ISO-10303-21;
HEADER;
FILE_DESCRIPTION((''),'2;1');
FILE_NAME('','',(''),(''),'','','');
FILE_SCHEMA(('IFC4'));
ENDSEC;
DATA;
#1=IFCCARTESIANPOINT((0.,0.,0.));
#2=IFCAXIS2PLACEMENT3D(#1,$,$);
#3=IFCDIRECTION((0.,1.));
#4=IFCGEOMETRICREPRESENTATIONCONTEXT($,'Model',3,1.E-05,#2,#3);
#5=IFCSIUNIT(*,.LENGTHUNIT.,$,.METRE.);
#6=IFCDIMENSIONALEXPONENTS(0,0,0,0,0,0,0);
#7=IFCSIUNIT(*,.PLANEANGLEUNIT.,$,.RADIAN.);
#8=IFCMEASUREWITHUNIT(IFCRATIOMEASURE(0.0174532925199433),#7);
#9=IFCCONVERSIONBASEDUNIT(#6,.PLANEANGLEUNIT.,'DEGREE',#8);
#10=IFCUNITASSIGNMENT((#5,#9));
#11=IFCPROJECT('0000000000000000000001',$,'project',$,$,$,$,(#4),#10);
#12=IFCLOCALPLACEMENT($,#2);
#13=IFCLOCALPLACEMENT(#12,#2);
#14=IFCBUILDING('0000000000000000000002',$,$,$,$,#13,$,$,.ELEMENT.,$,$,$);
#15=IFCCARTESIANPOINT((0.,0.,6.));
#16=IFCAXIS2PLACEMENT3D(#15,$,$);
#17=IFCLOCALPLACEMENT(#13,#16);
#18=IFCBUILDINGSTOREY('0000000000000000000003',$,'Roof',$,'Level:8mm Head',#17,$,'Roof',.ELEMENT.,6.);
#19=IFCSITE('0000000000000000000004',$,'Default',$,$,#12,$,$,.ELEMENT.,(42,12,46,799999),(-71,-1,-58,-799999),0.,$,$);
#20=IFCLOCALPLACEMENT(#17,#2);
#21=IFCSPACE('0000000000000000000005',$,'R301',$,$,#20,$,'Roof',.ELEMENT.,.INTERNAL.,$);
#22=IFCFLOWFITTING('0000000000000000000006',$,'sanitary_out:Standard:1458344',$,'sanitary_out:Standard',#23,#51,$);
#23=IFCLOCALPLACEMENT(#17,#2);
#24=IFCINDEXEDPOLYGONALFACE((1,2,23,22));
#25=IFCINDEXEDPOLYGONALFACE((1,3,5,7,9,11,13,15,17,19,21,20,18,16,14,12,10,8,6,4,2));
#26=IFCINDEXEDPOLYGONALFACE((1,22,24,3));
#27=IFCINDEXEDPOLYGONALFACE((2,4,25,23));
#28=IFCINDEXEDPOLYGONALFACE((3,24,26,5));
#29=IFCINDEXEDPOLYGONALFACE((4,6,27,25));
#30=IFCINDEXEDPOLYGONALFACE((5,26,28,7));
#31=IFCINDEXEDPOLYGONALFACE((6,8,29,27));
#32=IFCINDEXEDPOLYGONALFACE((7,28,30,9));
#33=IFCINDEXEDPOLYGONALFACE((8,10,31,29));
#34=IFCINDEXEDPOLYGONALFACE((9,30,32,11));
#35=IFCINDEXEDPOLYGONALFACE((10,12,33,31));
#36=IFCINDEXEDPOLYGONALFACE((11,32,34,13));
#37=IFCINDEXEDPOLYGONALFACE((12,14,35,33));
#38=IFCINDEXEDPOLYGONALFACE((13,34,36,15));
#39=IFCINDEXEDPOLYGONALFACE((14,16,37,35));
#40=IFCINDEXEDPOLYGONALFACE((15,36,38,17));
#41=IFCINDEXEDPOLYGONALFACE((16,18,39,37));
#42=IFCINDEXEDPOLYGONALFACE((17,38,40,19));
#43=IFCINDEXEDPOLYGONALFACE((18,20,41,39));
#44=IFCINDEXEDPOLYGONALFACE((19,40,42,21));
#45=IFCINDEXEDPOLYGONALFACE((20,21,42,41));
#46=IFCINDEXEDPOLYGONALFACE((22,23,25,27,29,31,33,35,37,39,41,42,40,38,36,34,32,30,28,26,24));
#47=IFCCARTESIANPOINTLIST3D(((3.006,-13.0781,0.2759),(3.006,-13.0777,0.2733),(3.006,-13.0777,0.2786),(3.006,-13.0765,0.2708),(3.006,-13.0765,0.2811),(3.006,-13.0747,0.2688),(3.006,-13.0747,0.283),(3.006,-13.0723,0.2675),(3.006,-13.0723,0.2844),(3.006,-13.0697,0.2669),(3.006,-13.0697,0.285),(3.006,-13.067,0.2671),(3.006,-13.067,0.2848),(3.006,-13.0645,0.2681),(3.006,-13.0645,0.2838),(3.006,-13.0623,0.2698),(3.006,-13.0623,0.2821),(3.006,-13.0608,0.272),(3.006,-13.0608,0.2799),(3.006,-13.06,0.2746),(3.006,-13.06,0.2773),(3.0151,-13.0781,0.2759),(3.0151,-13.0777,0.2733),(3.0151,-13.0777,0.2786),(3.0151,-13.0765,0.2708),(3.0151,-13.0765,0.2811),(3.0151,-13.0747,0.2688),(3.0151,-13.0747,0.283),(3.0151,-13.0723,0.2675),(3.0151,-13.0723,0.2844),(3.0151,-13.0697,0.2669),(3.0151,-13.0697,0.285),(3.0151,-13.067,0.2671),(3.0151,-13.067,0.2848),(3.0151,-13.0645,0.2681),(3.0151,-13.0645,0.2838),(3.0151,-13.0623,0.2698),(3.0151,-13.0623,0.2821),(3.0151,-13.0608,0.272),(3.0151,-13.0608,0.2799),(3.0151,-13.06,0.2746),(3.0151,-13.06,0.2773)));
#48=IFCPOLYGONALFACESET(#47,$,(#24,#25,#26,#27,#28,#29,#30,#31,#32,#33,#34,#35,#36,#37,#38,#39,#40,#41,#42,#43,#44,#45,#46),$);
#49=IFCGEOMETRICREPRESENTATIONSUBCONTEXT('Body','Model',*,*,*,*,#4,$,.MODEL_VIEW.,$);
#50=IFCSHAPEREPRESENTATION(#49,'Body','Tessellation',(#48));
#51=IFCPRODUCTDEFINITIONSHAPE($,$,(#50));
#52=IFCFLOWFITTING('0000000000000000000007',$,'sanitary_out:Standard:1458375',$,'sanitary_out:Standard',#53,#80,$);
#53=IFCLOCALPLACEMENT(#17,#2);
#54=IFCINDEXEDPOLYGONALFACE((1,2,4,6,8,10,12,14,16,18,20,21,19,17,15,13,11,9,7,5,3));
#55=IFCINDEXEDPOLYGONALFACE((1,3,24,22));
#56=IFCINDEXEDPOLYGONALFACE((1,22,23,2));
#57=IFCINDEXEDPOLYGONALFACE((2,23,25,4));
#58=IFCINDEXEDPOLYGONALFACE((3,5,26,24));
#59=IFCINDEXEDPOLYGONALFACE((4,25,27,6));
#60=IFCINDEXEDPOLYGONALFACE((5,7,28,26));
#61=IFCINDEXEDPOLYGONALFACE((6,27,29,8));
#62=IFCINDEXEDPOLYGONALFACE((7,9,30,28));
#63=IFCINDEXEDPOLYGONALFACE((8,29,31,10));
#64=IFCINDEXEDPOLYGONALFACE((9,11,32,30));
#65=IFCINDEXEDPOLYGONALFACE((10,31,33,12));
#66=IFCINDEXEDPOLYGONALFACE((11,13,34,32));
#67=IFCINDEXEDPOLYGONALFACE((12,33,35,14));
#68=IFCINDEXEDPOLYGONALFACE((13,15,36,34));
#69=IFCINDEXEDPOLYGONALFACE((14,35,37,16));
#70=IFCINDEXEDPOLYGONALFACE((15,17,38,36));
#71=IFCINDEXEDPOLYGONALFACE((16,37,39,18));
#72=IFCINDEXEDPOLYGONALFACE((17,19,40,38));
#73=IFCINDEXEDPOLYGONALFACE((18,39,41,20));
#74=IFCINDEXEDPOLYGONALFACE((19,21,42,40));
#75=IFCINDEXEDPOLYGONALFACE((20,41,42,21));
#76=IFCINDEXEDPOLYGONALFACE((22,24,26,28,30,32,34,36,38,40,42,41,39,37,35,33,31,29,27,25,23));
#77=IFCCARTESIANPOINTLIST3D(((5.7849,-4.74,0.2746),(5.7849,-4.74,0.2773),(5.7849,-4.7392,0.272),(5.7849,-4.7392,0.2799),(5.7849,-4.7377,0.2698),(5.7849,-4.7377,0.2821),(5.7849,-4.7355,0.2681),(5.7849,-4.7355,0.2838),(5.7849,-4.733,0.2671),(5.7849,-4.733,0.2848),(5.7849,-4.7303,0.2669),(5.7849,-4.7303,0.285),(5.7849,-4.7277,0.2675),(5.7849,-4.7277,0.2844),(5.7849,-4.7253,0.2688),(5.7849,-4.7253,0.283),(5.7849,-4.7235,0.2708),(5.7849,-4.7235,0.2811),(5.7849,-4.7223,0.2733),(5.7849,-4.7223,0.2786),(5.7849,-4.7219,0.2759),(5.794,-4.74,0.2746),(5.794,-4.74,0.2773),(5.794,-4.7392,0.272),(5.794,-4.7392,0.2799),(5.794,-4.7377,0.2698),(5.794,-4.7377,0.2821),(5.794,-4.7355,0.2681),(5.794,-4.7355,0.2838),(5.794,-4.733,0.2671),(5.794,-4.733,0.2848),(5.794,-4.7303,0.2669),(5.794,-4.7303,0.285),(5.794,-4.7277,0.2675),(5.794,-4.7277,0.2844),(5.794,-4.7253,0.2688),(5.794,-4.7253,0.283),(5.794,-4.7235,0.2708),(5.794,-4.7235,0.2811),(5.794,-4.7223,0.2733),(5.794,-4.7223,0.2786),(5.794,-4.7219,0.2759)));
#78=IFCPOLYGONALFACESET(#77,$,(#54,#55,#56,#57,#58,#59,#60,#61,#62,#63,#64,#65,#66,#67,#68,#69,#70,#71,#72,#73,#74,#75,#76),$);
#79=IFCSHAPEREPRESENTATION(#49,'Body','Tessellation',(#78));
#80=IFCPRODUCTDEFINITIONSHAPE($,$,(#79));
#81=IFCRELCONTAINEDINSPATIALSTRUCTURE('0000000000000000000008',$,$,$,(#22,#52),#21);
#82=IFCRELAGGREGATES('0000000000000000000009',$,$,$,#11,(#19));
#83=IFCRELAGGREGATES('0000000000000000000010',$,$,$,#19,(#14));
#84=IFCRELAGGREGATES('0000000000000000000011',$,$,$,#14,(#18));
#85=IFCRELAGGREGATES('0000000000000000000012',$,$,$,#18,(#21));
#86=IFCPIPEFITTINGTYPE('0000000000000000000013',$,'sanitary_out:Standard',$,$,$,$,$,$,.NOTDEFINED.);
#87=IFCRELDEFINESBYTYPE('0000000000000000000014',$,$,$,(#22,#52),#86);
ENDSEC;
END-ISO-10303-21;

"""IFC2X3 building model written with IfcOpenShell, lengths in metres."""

from ifc_helpers import new_model, entity, si_unit, converted_unit, direction, frame, frame_2d, origin, place, context, subcontext, project, spatial, circle, extrude, source, transform, mapped, type_object, type_shapes, element, save


model = new_model("IFC2X3")

# Units and contexts
model_context = context("Model", 3, precision=1e-05, world=origin(), true_north=direction((0.0, 1.0)))
body_context = subcontext(model_context, "Body", "Model", "MODEL_VIEW")
ifc_project = project(units=[si_unit("LENGTHUNIT", "METRE"), converted_unit("PLANEANGLEUNIT", "DEGREE", entity("IfcRatioMeasure", 0.0174532925199433), si_unit("PLANEANGLEUNIT", "RADIAN"), dimensions=[0, 0, 0, 0, 0, 0, 0])], contexts=[model_context])

# Site, building, storey
site_placement = place(None, origin())
site = spatial("IfcSite", under=ifc_project, at=site_placement, Name="Default", CompositionType="ELEMENT", RefLatitude=(42, 12, 46, 799999), RefLongitude=(-71, -1, -58, -799999), RefElevation=0.0)
building_placement = place(site_placement, origin())
building = spatial("IfcBuilding", under=site, at=building_placement, CompositionType="ELEMENT")
storey_placement = place(building_placement, frame((0.0, 0.0, 6.0)))
storey = spatial("IfcBuildingStorey", under=building, at=storey_placement, Name="Roof", ObjectType="Level:8mm Head", LongName="Roof", CompositionType="ELEMENT", Elevation=6.0)

# Shared definitions
space_placement = place(storey_placement, origin())
space = spatial("IfcSpace", under=storey, at=space_placement, Name="R301", LongName="Roof", CompositionType="ELEMENT", InteriorOrExteriorSpace="INTERNAL")

# Flow fittings
pipe_fitting_type = type_object("IfcPipeFittingType", Name="sanitary_out:Standard", PredefinedType="NOTDEFINED")
shared_shape = source(origin(), body_context, "Body", "SweptSolid", [
    extrude(circle(Radius=0.0091, at=frame_2d((0.0, 0.0), x_axis=(1.0, 0.0))), frame((0.0, 0.0, 0.0), z_axis=(1.0, 0.0, 0.0), x_axis=(0.0, 1.0, 0.0)), (0.0, 0.0, 1.0), 0.0091),
])
type_shapes(pipe_fitting_type, [shared_shape])
flow_fitting_1_placement = place(space_placement, frame((3.0151, -13.069, 0.2759), z_axis=(0.0, 0.0, 1.0), x_axis=(-1.0, 0.0, 0.0)))
element("IfcFlowFitting", 1, at=flow_fitting_1_placement, inside=space, type_object=pipe_fitting_type, Name="sanitary_out:Standard:1458344", ObjectType="sanitary_out:Standard", context=body_context, shape_type="MappedRepresentation", body=[
    mapped(shared_shape, transform((0.0, 0.0, 0.0), scale=1.0)),
])
flow_fitting_2_placement = place(space_placement, frame((5.7849, -4.731, 0.2759)))
element("IfcFlowFitting", 2, at=flow_fitting_2_placement, inside=space, type_object=pipe_fitting_type, Name="sanitary_out:Standard:1458375", ObjectType="sanitary_out:Standard", context=body_context, shape_type="MappedRepresentation", body=[
    mapped(shared_shape, transform((0.0, 0.0, 0.0), scale=1.0)),
])

save(model, "model.ifc")
